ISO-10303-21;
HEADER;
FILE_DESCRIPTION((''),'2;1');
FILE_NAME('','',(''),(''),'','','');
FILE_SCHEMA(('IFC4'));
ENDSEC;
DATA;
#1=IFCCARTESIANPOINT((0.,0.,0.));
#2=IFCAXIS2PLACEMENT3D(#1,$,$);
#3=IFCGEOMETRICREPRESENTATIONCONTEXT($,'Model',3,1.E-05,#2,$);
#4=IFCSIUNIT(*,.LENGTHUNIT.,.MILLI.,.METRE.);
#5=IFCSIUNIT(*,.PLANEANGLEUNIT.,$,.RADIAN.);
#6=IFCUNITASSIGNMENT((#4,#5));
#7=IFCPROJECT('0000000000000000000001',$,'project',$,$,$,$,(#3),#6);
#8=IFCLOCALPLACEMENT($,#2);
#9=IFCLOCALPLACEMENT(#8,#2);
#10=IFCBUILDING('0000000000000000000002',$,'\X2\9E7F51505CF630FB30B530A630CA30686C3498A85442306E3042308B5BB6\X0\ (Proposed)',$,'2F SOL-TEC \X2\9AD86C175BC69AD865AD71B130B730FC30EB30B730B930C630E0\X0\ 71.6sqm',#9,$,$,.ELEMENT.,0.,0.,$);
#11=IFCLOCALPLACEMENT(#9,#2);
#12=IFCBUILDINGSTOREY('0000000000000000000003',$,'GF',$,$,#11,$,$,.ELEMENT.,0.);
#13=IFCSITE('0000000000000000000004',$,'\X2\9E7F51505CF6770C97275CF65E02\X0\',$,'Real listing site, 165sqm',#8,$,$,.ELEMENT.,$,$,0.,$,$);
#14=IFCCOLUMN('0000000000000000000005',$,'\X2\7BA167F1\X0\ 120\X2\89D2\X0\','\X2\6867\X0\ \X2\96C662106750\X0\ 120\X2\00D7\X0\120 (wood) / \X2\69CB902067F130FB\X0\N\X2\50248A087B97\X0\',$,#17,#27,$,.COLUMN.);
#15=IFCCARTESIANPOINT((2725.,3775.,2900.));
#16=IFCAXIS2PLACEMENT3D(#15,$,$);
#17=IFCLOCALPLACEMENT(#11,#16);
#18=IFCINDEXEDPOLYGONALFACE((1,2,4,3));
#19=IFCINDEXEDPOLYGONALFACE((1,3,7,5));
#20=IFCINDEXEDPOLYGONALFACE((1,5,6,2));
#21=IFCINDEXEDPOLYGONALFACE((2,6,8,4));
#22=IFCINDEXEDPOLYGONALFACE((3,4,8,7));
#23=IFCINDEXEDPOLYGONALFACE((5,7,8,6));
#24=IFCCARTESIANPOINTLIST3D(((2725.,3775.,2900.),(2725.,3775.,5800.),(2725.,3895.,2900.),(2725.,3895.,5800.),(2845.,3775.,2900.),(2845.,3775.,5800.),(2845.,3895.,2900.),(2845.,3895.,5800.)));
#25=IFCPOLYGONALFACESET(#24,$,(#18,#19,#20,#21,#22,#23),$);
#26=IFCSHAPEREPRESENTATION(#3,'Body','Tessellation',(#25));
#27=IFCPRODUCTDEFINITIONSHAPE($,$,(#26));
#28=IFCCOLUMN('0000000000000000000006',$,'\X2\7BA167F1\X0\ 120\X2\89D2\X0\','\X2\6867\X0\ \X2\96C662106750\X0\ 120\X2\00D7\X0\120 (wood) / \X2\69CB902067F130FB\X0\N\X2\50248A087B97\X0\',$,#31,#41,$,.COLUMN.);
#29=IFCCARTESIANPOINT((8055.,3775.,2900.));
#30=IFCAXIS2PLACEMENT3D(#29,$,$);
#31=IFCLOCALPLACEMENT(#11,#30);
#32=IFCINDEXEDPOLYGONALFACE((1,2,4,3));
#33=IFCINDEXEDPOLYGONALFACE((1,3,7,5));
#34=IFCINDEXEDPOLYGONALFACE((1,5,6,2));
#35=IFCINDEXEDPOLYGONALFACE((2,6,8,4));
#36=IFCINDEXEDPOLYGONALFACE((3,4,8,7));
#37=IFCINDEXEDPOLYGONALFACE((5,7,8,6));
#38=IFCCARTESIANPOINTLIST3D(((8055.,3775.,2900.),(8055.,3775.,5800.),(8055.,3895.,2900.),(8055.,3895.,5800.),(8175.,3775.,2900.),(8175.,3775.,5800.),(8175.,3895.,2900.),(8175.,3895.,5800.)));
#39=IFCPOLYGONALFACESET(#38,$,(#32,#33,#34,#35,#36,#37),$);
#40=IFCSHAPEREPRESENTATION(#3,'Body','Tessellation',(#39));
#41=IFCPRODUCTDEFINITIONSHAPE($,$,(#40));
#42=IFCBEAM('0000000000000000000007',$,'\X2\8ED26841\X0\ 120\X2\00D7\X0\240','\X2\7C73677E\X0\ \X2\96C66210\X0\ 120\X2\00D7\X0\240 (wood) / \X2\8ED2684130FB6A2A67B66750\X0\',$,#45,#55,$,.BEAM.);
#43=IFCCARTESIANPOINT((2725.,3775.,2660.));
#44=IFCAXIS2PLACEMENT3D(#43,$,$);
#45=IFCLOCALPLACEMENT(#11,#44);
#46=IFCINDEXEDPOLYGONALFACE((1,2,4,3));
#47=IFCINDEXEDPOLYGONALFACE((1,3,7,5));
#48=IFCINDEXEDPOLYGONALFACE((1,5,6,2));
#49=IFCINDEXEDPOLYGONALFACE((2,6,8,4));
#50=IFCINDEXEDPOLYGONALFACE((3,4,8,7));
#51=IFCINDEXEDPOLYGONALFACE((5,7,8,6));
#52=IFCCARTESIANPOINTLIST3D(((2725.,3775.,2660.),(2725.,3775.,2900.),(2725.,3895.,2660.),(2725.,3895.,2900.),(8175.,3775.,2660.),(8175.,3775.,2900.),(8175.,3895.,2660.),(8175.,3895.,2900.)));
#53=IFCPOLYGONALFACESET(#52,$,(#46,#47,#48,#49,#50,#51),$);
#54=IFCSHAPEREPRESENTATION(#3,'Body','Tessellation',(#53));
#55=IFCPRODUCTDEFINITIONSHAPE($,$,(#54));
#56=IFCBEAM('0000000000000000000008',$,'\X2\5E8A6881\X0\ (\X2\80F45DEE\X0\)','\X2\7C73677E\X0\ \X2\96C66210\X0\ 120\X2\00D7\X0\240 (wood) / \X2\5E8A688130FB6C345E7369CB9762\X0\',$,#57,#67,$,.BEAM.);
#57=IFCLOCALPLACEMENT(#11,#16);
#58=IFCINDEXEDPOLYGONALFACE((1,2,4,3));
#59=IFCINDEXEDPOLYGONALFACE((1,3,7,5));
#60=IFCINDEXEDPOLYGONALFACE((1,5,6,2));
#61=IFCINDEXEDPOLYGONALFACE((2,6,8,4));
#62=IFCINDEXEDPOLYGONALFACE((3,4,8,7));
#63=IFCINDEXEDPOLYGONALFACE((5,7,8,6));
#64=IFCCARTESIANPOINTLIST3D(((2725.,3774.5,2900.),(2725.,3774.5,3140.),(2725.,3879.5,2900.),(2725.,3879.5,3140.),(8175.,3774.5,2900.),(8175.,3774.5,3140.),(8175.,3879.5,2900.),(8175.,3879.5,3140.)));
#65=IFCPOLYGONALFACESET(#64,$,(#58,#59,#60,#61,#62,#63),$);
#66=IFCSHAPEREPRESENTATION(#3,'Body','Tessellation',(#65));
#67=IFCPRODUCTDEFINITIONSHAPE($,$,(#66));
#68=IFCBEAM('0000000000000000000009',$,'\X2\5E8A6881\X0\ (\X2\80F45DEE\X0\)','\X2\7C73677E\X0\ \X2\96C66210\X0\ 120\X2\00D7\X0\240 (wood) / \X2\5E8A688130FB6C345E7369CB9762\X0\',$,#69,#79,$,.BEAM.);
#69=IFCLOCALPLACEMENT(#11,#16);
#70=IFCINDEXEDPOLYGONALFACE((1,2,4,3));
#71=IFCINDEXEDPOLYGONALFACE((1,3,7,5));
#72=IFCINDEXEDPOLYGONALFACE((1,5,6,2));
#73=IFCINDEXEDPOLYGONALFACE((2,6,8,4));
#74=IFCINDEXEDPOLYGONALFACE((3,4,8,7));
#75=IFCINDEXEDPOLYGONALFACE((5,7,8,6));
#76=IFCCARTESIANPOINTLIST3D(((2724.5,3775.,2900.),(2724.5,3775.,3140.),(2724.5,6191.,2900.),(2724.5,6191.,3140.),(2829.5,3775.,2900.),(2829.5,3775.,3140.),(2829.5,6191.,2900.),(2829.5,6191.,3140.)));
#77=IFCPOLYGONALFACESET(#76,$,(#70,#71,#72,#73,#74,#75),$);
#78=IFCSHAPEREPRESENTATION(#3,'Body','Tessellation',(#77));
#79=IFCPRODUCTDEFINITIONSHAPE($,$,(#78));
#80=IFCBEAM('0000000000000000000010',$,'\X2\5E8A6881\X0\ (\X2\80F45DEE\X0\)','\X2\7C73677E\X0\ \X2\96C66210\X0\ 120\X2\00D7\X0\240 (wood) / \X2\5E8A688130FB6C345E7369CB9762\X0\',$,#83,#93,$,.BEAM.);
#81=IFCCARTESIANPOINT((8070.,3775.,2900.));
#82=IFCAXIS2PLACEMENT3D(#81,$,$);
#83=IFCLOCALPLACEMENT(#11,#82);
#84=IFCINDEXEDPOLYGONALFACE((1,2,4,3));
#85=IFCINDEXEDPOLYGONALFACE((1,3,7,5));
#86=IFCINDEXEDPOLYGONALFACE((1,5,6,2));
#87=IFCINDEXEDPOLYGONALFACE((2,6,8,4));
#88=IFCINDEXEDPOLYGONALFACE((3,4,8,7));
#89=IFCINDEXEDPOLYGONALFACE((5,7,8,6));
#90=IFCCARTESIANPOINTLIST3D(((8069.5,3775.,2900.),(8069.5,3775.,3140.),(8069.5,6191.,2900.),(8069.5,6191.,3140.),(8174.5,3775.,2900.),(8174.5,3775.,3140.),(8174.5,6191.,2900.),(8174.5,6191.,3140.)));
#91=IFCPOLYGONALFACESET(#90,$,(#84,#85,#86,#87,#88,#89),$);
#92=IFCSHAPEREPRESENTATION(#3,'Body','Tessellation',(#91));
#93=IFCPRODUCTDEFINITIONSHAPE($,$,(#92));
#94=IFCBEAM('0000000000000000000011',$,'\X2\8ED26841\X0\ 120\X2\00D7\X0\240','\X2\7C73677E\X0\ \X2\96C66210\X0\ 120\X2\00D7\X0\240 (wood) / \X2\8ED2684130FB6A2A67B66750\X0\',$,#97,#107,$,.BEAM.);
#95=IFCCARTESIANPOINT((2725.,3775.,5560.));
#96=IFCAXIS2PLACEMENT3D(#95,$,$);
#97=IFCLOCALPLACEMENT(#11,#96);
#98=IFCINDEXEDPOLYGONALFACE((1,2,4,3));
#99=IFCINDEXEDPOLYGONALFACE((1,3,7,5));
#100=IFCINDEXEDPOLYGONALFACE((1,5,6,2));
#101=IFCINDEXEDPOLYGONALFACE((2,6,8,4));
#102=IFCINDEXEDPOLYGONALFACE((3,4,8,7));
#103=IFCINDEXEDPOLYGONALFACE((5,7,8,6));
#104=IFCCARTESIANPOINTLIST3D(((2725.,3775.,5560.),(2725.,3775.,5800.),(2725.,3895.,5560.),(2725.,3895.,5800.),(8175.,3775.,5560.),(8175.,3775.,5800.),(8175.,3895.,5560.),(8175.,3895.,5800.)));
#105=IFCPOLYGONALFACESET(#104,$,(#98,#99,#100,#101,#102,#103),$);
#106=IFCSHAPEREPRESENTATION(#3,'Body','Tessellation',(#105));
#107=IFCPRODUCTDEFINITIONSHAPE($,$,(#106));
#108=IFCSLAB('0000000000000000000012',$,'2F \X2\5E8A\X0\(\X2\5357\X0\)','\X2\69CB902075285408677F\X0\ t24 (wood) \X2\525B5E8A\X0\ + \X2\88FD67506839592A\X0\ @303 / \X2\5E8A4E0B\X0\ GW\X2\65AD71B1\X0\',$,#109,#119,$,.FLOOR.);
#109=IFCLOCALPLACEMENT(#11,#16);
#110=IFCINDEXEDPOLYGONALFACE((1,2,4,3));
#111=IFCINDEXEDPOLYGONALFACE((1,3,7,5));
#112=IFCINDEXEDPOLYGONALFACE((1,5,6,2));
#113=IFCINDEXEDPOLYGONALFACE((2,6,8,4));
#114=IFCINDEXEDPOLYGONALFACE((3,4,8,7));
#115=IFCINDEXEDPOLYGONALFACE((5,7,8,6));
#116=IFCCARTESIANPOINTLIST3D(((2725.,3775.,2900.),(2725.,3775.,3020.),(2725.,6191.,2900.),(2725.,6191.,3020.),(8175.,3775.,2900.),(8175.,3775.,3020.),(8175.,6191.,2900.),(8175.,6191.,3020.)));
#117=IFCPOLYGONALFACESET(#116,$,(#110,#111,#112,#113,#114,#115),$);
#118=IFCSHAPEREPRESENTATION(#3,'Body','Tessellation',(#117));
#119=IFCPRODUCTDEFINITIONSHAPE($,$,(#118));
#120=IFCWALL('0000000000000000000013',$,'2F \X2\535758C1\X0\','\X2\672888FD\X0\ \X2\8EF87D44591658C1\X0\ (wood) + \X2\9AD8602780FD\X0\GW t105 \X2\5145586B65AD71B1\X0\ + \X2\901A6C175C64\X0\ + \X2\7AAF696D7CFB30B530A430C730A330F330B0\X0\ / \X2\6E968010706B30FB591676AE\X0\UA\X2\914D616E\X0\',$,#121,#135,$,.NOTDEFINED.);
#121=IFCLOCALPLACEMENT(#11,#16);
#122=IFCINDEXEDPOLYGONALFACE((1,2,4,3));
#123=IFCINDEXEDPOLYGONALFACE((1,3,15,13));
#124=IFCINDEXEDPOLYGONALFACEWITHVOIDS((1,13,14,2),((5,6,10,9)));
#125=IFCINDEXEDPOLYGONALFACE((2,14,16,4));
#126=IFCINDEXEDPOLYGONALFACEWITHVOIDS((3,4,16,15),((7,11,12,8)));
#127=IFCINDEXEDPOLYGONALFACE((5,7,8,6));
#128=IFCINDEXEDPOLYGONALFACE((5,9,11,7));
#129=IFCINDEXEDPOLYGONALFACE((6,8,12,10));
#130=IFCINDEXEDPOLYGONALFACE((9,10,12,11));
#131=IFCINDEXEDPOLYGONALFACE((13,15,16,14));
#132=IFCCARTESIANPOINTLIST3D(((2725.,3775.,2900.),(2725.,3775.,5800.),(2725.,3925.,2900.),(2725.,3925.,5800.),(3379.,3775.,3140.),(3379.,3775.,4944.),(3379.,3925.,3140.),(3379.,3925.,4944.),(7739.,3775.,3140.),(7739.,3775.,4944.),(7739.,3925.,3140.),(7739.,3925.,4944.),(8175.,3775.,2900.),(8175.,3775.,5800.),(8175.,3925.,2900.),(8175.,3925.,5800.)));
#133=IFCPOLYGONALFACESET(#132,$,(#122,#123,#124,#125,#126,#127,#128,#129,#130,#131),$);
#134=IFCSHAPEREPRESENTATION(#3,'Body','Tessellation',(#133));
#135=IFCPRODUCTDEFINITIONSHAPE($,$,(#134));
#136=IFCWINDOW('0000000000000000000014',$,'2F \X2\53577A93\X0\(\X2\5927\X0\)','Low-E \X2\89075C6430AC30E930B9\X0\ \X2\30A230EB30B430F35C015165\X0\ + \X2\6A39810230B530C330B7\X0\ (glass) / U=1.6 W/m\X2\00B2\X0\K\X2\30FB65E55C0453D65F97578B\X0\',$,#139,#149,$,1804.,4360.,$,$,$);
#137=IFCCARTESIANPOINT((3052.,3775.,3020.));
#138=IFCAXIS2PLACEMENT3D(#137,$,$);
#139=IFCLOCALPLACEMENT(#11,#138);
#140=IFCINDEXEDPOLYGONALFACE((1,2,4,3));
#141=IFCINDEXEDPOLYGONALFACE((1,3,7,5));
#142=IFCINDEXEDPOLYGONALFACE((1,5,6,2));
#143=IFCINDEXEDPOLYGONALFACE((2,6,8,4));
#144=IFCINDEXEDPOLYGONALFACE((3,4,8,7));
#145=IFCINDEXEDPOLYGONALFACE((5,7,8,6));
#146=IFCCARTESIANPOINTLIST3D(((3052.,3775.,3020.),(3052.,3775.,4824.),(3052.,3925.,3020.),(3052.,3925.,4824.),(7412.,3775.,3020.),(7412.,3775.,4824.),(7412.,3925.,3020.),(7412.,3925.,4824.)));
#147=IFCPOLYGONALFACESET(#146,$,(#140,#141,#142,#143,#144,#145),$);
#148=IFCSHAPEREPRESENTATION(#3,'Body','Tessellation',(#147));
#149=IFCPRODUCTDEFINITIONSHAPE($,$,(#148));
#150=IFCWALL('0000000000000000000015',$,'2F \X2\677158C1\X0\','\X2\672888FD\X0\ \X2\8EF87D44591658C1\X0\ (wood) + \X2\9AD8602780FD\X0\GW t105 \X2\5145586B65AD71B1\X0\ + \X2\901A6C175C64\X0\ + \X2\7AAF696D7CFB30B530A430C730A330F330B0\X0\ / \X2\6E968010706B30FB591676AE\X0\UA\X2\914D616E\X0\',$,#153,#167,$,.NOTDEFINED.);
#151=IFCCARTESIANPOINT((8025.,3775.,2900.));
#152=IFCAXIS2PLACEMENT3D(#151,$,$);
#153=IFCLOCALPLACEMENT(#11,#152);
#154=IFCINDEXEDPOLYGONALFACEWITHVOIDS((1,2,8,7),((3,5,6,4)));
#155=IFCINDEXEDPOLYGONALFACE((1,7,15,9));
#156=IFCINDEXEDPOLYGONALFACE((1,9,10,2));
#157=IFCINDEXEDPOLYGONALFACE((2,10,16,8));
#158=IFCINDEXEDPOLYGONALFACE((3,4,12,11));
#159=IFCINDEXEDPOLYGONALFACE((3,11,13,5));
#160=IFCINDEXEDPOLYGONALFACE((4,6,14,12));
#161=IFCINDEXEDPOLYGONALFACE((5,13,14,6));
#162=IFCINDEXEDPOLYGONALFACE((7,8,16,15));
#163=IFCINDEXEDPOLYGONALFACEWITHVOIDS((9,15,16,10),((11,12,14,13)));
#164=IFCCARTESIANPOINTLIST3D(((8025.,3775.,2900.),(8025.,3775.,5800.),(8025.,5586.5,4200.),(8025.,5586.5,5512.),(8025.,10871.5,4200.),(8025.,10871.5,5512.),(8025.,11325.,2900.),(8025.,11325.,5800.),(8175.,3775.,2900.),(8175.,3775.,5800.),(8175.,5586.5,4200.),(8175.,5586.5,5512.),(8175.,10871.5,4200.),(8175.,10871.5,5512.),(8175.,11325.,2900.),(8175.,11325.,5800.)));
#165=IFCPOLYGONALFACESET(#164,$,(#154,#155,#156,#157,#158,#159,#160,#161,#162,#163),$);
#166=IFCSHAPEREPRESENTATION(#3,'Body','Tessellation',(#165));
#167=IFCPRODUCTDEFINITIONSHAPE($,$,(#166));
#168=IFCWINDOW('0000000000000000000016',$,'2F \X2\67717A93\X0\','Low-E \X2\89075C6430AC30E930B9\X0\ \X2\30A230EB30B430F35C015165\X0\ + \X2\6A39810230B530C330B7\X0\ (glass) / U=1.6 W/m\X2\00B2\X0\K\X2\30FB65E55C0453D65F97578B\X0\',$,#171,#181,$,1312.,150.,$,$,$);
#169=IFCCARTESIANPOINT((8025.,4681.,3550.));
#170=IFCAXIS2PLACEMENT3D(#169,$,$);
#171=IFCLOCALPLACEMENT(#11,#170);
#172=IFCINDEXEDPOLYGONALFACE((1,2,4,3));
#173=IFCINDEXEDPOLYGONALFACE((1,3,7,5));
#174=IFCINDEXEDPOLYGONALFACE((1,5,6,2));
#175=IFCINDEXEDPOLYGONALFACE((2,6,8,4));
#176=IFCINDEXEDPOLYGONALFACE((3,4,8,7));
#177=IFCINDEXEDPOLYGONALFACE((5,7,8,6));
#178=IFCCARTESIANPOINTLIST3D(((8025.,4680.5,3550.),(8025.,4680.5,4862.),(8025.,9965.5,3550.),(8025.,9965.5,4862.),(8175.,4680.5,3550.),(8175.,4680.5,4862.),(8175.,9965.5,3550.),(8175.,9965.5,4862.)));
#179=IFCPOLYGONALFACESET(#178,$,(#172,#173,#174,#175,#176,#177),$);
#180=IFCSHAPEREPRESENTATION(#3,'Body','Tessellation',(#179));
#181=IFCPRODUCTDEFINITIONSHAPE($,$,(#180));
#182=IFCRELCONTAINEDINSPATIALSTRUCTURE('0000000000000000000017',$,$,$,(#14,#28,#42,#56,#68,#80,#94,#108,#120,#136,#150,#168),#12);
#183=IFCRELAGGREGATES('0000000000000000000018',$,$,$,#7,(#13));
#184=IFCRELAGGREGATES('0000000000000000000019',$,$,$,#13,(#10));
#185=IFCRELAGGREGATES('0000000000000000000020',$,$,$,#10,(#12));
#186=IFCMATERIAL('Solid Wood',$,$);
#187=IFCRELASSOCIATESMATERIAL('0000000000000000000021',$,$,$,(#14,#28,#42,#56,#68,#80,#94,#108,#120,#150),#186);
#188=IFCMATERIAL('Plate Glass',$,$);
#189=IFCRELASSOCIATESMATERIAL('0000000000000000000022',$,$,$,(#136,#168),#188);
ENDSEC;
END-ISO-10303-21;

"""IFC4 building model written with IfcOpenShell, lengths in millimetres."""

from ifc_helpers import new_model, si_unit, frame, frame_2d, origin, place, context, project, spatial, rectangle, extrude, material, element, fill, save


model = new_model("IFC4")

# Units and contexts
model_context = context("Model", 3, precision=1e-05, world=origin())
ifc_project = project(units=[si_unit("LENGTHUNIT", "METRE", prefix="MILLI"), si_unit("PLANEANGLEUNIT", "RADIAN")], contexts=[model_context])

# Site, building, storey
site_placement = place(None, origin())
site = spatial("IfcSite", under=ifc_project, at=site_placement, Name="鹿児島県霧島市", ObjectType="Real listing site, 165sqm", CompositionType="ELEMENT", RefElevation=0.0)
building_placement = place(site_placement, origin())
building = spatial("IfcBuilding", under=site, at=building_placement, Name="鹿児島・サウナと水風呂のある家 (Proposed)", ObjectType="2F SOL-TEC 高気密高断熱シールシステム 71.6sqm", CompositionType="ELEMENT", ElevationOfRefHeight=0.0, ElevationOfTerrain=0.0)
storey_placement = place(building_placement, origin())
storey = spatial("IfcBuildingStorey", under=building, at=storey_placement, Name="GF", CompositionType="ELEMENT", Elevation=0.0)

# Columns
ifc_material_1 = material(Name="Solid Wood")
column_1_placement = place(storey_placement, frame((2725.0, 3775.0, 2900.0)))
element("IfcColumn", 1, at=column_1_placement, inside=storey, material=ifc_material_1, Name="管柱 120角", Description="桧 集成材 120×120 (wood) / 構造柱・N値計算", PredefinedType="COLUMN", context=model_context, shape_type="SweptSolid", body=[
    extrude(rectangle(XDim=120.0, YDim=120.0, at=frame_2d((60.0, 60.0))), frame((2725.0, 3775.0, 2900.0)), (0.0, 0.0, 1.0), 2900.0),
])
column_2_placement = place(storey_placement, frame((8055.0, 3775.0, 2900.0)))
element("IfcColumn", 2, at=column_2_placement, inside=storey, material=ifc_material_1, Name="管柱 120角", Description="桧 集成材 120×120 (wood) / 構造柱・N値計算", PredefinedType="COLUMN", context=model_context, shape_type="SweptSolid", body=[
    extrude(rectangle(XDim=120.0, YDim=120.0, at=frame_2d((60.0, 60.0))), frame((8055.0, 3775.0, 2900.0)), (0.0, 0.0, 1.0), 2900.0),
])

# Beams
beam_1_placement = place(storey_placement, frame((2725.0, 3775.0, 2660.0)))
element("IfcBeam", 3, at=beam_1_placement, inside=storey, material=ifc_material_1, Name="軒桁 120×240", Description="米松 集成 120×240 (wood) / 軒桁・横架材", PredefinedType="BEAM", context=model_context, shape_type="SweptSolid", body=[
    extrude(rectangle(XDim=5450.0, YDim=120.0, at=frame_2d((2725.0, 60.0))), frame((2725.0, 3775.0, 2660.0)), (0.0, 0.0, 1.0), 240.0),
])
beam_2_placement = place(storey_placement, frame((2725.0, 3775.0, 2900.0)))
element("IfcBeam", 4, at=beam_2_placement, inside=storey, material=ifc_material_1, Name="床梁 (胴差)", Description="米松 集成 120×240 (wood) / 床梁・水平構面", PredefinedType="BEAM", context=model_context, shape_type="SweptSolid", body=[
    extrude(rectangle(XDim=5450.0, YDim=105.0, at=frame_2d((2725.0, 52.0))), frame((2725.0, 3775.0, 2900.0)), (0.0, 0.0, 1.0), 240.0),
])
beam_3_placement = place(storey_placement, frame((2725.0, 3775.0, 2900.0)))
element("IfcBeam", 5, at=beam_3_placement, inside=storey, material=ifc_material_1, Name="床梁 (胴差)", Description="米松 集成 120×240 (wood) / 床梁・水平構面", PredefinedType="BEAM", context=model_context, shape_type="SweptSolid", body=[
    extrude(rectangle(XDim=105.0, YDim=2416.0, at=frame_2d((52.0, 1208.0))), frame((2725.0, 3775.0, 2900.0)), (0.0, 0.0, 1.0), 240.0),
])
beam_4_placement = place(storey_placement, frame((8070.0, 3775.0, 2900.0)))
element("IfcBeam", 6, at=beam_4_placement, inside=storey, material=ifc_material_1, Name="床梁 (胴差)", Description="米松 集成 120×240 (wood) / 床梁・水平構面", PredefinedType="BEAM", context=model_context, shape_type="SweptSolid", body=[
    extrude(rectangle(XDim=105.0, YDim=2416.0, at=frame_2d((52.0, 1208.0))), frame((8070.0, 3775.0, 2900.0)), (0.0, 0.0, 1.0), 240.0),
])
beam_5_placement = place(storey_placement, frame((2725.0, 3775.0, 5560.0)))
element("IfcBeam", 7, at=beam_5_placement, inside=storey, material=ifc_material_1, Name="軒桁 120×240", Description="米松 集成 120×240 (wood) / 軒桁・横架材", PredefinedType="BEAM", context=model_context, shape_type="SweptSolid", body=[
    extrude(rectangle(XDim=5450.0, YDim=120.0, at=frame_2d((2725.0, 60.0))), frame((2725.0, 3775.0, 5560.0)), (0.0, 0.0, 1.0), 240.0),
])

# Slab
slab_placement = place(storey_placement, frame((2725.0, 3775.0, 2900.0)))
element("IfcSlab", 8, at=slab_placement, inside=storey, material=ifc_material_1, Name="2F 床(南)", Description="構造用合板 t24 (wood) 剛床 + 製材根太 @303 / 床下 GW断熱", PredefinedType="FLOOR", context=model_context, shape_type="SweptSolid", body=[
    extrude(rectangle(XDim=5450.0, YDim=2416.0, at=frame_2d((2725.0, 1208.0))), frame((2725.0, 3775.0, 2900.0)), (0.0, 0.0, 1.0), 120.0),
])

# Walls, openings, windows
wall_1_placement = place(storey_placement, frame((2725.0, 3775.0, 2900.0)))
wall_1 = element("IfcWall", 9, at=wall_1_placement, inside=storey, material=ifc_material_1, Name="2F 南壁", Description="木製 軸組外壁 (wood) + 高性能GW t105 充填断熱 + 通気層 + 窯業系サイディング / 準耐火・外皮UA配慮", PredefinedType="NOTDEFINED", context=model_context, shape_type="SweptSolid", body=[
    extrude(rectangle(XDim=5450.0, YDim=150.0, at=frame_2d((2725.0, 75.0))), frame((2725.0, 3775.0, 2900.0)), (0.0, 0.0, 1.0), 2900.0),
])
opening_1_placement = place(storey_placement, frame((3052.0, 3775.0, 3020.0)))
opening_1 = element("IfcOpeningElement", 10, at=opening_1_placement, cuts=wall_1, PredefinedType="NOTDEFINED", context=model_context, shape_type="SweptSolid", body=[
    extrude(rectangle(XDim=4360.0, YDim=150.0, at=frame_2d((2180.0, 75.0))), frame((3052.0, 3775.0, 3020.0)), (0.0, 0.0, 1.0), 1804.0),
])
ifc_material_2 = material(Name="Plate Glass")
window_1_placement = place(storey_placement, frame((3052.0, 3775.0, 3020.0)))
window_1 = element("IfcWindow", 11, at=window_1_placement, inside=storey, material=ifc_material_2, Name="2F 南窓(大)", Description="Low-E 複層ガラス アルゴン封入 + 樹脂サッシ (glass) / U=1.6 W/m²K・日射取得型", OverallHeight=1804.0, OverallWidth=4360.0, context=model_context, shape_type="SweptSolid", body=[
    extrude(rectangle(XDim=4360.0, YDim=150.0, at=frame_2d((2180.0, 75.0))), frame((3052.0, 3775.0, 3020.0)), (0.0, 0.0, 1.0), 1804.0),
])
fill(opening_1, window_1)
wall_2_placement = place(storey_placement, frame((8025.0, 3775.0, 2900.0)))
wall_2 = element("IfcWall", 12, at=wall_2_placement, inside=storey, material=ifc_material_1, Name="2F 東壁", Description="木製 軸組外壁 (wood) + 高性能GW t105 充填断熱 + 通気層 + 窯業系サイディング / 準耐火・外皮UA配慮", PredefinedType="NOTDEFINED", context=model_context, shape_type="SweptSolid", body=[
    extrude(rectangle(XDim=150.0, YDim=7550.0, at=frame_2d((75.0, 3775.0))), frame((8025.0, 3775.0, 2900.0)), (0.0, 0.0, 1.0), 2900.0),
])
opening_2_placement = place(storey_placement, frame((8025.0, 4681.0, 3550.0)))
opening_2 = element("IfcOpeningElement", 13, at=opening_2_placement, cuts=wall_2, PredefinedType="NOTDEFINED", context=model_context, shape_type="SweptSolid", body=[
    extrude(rectangle(XDim=150.0, YDim=5285.0, at=frame_2d((75.0, 2642.0))), frame((8025.0, 4681.0, 3550.0)), (0.0, 0.0, 1.0), 1312.0),
])
window_2_placement = place(storey_placement, frame((8025.0, 4681.0, 3550.0)))
window_2 = element("IfcWindow", 14, at=window_2_placement, inside=storey, material=ifc_material_2, Name="2F 東窓", Description="Low-E 複層ガラス アルゴン封入 + 樹脂サッシ (glass) / U=1.6 W/m²K・日射取得型", OverallHeight=1312.0, OverallWidth=150.0, context=model_context, shape_type="SweptSolid", body=[
    extrude(rectangle(XDim=150.0, YDim=5285.0, at=frame_2d((75.0, 2642.0))), frame((8025.0, 4681.0, 3550.0)), (0.0, 0.0, 1.0), 1312.0),
])
fill(opening_2, window_2)

save(model, "model.ifc")
